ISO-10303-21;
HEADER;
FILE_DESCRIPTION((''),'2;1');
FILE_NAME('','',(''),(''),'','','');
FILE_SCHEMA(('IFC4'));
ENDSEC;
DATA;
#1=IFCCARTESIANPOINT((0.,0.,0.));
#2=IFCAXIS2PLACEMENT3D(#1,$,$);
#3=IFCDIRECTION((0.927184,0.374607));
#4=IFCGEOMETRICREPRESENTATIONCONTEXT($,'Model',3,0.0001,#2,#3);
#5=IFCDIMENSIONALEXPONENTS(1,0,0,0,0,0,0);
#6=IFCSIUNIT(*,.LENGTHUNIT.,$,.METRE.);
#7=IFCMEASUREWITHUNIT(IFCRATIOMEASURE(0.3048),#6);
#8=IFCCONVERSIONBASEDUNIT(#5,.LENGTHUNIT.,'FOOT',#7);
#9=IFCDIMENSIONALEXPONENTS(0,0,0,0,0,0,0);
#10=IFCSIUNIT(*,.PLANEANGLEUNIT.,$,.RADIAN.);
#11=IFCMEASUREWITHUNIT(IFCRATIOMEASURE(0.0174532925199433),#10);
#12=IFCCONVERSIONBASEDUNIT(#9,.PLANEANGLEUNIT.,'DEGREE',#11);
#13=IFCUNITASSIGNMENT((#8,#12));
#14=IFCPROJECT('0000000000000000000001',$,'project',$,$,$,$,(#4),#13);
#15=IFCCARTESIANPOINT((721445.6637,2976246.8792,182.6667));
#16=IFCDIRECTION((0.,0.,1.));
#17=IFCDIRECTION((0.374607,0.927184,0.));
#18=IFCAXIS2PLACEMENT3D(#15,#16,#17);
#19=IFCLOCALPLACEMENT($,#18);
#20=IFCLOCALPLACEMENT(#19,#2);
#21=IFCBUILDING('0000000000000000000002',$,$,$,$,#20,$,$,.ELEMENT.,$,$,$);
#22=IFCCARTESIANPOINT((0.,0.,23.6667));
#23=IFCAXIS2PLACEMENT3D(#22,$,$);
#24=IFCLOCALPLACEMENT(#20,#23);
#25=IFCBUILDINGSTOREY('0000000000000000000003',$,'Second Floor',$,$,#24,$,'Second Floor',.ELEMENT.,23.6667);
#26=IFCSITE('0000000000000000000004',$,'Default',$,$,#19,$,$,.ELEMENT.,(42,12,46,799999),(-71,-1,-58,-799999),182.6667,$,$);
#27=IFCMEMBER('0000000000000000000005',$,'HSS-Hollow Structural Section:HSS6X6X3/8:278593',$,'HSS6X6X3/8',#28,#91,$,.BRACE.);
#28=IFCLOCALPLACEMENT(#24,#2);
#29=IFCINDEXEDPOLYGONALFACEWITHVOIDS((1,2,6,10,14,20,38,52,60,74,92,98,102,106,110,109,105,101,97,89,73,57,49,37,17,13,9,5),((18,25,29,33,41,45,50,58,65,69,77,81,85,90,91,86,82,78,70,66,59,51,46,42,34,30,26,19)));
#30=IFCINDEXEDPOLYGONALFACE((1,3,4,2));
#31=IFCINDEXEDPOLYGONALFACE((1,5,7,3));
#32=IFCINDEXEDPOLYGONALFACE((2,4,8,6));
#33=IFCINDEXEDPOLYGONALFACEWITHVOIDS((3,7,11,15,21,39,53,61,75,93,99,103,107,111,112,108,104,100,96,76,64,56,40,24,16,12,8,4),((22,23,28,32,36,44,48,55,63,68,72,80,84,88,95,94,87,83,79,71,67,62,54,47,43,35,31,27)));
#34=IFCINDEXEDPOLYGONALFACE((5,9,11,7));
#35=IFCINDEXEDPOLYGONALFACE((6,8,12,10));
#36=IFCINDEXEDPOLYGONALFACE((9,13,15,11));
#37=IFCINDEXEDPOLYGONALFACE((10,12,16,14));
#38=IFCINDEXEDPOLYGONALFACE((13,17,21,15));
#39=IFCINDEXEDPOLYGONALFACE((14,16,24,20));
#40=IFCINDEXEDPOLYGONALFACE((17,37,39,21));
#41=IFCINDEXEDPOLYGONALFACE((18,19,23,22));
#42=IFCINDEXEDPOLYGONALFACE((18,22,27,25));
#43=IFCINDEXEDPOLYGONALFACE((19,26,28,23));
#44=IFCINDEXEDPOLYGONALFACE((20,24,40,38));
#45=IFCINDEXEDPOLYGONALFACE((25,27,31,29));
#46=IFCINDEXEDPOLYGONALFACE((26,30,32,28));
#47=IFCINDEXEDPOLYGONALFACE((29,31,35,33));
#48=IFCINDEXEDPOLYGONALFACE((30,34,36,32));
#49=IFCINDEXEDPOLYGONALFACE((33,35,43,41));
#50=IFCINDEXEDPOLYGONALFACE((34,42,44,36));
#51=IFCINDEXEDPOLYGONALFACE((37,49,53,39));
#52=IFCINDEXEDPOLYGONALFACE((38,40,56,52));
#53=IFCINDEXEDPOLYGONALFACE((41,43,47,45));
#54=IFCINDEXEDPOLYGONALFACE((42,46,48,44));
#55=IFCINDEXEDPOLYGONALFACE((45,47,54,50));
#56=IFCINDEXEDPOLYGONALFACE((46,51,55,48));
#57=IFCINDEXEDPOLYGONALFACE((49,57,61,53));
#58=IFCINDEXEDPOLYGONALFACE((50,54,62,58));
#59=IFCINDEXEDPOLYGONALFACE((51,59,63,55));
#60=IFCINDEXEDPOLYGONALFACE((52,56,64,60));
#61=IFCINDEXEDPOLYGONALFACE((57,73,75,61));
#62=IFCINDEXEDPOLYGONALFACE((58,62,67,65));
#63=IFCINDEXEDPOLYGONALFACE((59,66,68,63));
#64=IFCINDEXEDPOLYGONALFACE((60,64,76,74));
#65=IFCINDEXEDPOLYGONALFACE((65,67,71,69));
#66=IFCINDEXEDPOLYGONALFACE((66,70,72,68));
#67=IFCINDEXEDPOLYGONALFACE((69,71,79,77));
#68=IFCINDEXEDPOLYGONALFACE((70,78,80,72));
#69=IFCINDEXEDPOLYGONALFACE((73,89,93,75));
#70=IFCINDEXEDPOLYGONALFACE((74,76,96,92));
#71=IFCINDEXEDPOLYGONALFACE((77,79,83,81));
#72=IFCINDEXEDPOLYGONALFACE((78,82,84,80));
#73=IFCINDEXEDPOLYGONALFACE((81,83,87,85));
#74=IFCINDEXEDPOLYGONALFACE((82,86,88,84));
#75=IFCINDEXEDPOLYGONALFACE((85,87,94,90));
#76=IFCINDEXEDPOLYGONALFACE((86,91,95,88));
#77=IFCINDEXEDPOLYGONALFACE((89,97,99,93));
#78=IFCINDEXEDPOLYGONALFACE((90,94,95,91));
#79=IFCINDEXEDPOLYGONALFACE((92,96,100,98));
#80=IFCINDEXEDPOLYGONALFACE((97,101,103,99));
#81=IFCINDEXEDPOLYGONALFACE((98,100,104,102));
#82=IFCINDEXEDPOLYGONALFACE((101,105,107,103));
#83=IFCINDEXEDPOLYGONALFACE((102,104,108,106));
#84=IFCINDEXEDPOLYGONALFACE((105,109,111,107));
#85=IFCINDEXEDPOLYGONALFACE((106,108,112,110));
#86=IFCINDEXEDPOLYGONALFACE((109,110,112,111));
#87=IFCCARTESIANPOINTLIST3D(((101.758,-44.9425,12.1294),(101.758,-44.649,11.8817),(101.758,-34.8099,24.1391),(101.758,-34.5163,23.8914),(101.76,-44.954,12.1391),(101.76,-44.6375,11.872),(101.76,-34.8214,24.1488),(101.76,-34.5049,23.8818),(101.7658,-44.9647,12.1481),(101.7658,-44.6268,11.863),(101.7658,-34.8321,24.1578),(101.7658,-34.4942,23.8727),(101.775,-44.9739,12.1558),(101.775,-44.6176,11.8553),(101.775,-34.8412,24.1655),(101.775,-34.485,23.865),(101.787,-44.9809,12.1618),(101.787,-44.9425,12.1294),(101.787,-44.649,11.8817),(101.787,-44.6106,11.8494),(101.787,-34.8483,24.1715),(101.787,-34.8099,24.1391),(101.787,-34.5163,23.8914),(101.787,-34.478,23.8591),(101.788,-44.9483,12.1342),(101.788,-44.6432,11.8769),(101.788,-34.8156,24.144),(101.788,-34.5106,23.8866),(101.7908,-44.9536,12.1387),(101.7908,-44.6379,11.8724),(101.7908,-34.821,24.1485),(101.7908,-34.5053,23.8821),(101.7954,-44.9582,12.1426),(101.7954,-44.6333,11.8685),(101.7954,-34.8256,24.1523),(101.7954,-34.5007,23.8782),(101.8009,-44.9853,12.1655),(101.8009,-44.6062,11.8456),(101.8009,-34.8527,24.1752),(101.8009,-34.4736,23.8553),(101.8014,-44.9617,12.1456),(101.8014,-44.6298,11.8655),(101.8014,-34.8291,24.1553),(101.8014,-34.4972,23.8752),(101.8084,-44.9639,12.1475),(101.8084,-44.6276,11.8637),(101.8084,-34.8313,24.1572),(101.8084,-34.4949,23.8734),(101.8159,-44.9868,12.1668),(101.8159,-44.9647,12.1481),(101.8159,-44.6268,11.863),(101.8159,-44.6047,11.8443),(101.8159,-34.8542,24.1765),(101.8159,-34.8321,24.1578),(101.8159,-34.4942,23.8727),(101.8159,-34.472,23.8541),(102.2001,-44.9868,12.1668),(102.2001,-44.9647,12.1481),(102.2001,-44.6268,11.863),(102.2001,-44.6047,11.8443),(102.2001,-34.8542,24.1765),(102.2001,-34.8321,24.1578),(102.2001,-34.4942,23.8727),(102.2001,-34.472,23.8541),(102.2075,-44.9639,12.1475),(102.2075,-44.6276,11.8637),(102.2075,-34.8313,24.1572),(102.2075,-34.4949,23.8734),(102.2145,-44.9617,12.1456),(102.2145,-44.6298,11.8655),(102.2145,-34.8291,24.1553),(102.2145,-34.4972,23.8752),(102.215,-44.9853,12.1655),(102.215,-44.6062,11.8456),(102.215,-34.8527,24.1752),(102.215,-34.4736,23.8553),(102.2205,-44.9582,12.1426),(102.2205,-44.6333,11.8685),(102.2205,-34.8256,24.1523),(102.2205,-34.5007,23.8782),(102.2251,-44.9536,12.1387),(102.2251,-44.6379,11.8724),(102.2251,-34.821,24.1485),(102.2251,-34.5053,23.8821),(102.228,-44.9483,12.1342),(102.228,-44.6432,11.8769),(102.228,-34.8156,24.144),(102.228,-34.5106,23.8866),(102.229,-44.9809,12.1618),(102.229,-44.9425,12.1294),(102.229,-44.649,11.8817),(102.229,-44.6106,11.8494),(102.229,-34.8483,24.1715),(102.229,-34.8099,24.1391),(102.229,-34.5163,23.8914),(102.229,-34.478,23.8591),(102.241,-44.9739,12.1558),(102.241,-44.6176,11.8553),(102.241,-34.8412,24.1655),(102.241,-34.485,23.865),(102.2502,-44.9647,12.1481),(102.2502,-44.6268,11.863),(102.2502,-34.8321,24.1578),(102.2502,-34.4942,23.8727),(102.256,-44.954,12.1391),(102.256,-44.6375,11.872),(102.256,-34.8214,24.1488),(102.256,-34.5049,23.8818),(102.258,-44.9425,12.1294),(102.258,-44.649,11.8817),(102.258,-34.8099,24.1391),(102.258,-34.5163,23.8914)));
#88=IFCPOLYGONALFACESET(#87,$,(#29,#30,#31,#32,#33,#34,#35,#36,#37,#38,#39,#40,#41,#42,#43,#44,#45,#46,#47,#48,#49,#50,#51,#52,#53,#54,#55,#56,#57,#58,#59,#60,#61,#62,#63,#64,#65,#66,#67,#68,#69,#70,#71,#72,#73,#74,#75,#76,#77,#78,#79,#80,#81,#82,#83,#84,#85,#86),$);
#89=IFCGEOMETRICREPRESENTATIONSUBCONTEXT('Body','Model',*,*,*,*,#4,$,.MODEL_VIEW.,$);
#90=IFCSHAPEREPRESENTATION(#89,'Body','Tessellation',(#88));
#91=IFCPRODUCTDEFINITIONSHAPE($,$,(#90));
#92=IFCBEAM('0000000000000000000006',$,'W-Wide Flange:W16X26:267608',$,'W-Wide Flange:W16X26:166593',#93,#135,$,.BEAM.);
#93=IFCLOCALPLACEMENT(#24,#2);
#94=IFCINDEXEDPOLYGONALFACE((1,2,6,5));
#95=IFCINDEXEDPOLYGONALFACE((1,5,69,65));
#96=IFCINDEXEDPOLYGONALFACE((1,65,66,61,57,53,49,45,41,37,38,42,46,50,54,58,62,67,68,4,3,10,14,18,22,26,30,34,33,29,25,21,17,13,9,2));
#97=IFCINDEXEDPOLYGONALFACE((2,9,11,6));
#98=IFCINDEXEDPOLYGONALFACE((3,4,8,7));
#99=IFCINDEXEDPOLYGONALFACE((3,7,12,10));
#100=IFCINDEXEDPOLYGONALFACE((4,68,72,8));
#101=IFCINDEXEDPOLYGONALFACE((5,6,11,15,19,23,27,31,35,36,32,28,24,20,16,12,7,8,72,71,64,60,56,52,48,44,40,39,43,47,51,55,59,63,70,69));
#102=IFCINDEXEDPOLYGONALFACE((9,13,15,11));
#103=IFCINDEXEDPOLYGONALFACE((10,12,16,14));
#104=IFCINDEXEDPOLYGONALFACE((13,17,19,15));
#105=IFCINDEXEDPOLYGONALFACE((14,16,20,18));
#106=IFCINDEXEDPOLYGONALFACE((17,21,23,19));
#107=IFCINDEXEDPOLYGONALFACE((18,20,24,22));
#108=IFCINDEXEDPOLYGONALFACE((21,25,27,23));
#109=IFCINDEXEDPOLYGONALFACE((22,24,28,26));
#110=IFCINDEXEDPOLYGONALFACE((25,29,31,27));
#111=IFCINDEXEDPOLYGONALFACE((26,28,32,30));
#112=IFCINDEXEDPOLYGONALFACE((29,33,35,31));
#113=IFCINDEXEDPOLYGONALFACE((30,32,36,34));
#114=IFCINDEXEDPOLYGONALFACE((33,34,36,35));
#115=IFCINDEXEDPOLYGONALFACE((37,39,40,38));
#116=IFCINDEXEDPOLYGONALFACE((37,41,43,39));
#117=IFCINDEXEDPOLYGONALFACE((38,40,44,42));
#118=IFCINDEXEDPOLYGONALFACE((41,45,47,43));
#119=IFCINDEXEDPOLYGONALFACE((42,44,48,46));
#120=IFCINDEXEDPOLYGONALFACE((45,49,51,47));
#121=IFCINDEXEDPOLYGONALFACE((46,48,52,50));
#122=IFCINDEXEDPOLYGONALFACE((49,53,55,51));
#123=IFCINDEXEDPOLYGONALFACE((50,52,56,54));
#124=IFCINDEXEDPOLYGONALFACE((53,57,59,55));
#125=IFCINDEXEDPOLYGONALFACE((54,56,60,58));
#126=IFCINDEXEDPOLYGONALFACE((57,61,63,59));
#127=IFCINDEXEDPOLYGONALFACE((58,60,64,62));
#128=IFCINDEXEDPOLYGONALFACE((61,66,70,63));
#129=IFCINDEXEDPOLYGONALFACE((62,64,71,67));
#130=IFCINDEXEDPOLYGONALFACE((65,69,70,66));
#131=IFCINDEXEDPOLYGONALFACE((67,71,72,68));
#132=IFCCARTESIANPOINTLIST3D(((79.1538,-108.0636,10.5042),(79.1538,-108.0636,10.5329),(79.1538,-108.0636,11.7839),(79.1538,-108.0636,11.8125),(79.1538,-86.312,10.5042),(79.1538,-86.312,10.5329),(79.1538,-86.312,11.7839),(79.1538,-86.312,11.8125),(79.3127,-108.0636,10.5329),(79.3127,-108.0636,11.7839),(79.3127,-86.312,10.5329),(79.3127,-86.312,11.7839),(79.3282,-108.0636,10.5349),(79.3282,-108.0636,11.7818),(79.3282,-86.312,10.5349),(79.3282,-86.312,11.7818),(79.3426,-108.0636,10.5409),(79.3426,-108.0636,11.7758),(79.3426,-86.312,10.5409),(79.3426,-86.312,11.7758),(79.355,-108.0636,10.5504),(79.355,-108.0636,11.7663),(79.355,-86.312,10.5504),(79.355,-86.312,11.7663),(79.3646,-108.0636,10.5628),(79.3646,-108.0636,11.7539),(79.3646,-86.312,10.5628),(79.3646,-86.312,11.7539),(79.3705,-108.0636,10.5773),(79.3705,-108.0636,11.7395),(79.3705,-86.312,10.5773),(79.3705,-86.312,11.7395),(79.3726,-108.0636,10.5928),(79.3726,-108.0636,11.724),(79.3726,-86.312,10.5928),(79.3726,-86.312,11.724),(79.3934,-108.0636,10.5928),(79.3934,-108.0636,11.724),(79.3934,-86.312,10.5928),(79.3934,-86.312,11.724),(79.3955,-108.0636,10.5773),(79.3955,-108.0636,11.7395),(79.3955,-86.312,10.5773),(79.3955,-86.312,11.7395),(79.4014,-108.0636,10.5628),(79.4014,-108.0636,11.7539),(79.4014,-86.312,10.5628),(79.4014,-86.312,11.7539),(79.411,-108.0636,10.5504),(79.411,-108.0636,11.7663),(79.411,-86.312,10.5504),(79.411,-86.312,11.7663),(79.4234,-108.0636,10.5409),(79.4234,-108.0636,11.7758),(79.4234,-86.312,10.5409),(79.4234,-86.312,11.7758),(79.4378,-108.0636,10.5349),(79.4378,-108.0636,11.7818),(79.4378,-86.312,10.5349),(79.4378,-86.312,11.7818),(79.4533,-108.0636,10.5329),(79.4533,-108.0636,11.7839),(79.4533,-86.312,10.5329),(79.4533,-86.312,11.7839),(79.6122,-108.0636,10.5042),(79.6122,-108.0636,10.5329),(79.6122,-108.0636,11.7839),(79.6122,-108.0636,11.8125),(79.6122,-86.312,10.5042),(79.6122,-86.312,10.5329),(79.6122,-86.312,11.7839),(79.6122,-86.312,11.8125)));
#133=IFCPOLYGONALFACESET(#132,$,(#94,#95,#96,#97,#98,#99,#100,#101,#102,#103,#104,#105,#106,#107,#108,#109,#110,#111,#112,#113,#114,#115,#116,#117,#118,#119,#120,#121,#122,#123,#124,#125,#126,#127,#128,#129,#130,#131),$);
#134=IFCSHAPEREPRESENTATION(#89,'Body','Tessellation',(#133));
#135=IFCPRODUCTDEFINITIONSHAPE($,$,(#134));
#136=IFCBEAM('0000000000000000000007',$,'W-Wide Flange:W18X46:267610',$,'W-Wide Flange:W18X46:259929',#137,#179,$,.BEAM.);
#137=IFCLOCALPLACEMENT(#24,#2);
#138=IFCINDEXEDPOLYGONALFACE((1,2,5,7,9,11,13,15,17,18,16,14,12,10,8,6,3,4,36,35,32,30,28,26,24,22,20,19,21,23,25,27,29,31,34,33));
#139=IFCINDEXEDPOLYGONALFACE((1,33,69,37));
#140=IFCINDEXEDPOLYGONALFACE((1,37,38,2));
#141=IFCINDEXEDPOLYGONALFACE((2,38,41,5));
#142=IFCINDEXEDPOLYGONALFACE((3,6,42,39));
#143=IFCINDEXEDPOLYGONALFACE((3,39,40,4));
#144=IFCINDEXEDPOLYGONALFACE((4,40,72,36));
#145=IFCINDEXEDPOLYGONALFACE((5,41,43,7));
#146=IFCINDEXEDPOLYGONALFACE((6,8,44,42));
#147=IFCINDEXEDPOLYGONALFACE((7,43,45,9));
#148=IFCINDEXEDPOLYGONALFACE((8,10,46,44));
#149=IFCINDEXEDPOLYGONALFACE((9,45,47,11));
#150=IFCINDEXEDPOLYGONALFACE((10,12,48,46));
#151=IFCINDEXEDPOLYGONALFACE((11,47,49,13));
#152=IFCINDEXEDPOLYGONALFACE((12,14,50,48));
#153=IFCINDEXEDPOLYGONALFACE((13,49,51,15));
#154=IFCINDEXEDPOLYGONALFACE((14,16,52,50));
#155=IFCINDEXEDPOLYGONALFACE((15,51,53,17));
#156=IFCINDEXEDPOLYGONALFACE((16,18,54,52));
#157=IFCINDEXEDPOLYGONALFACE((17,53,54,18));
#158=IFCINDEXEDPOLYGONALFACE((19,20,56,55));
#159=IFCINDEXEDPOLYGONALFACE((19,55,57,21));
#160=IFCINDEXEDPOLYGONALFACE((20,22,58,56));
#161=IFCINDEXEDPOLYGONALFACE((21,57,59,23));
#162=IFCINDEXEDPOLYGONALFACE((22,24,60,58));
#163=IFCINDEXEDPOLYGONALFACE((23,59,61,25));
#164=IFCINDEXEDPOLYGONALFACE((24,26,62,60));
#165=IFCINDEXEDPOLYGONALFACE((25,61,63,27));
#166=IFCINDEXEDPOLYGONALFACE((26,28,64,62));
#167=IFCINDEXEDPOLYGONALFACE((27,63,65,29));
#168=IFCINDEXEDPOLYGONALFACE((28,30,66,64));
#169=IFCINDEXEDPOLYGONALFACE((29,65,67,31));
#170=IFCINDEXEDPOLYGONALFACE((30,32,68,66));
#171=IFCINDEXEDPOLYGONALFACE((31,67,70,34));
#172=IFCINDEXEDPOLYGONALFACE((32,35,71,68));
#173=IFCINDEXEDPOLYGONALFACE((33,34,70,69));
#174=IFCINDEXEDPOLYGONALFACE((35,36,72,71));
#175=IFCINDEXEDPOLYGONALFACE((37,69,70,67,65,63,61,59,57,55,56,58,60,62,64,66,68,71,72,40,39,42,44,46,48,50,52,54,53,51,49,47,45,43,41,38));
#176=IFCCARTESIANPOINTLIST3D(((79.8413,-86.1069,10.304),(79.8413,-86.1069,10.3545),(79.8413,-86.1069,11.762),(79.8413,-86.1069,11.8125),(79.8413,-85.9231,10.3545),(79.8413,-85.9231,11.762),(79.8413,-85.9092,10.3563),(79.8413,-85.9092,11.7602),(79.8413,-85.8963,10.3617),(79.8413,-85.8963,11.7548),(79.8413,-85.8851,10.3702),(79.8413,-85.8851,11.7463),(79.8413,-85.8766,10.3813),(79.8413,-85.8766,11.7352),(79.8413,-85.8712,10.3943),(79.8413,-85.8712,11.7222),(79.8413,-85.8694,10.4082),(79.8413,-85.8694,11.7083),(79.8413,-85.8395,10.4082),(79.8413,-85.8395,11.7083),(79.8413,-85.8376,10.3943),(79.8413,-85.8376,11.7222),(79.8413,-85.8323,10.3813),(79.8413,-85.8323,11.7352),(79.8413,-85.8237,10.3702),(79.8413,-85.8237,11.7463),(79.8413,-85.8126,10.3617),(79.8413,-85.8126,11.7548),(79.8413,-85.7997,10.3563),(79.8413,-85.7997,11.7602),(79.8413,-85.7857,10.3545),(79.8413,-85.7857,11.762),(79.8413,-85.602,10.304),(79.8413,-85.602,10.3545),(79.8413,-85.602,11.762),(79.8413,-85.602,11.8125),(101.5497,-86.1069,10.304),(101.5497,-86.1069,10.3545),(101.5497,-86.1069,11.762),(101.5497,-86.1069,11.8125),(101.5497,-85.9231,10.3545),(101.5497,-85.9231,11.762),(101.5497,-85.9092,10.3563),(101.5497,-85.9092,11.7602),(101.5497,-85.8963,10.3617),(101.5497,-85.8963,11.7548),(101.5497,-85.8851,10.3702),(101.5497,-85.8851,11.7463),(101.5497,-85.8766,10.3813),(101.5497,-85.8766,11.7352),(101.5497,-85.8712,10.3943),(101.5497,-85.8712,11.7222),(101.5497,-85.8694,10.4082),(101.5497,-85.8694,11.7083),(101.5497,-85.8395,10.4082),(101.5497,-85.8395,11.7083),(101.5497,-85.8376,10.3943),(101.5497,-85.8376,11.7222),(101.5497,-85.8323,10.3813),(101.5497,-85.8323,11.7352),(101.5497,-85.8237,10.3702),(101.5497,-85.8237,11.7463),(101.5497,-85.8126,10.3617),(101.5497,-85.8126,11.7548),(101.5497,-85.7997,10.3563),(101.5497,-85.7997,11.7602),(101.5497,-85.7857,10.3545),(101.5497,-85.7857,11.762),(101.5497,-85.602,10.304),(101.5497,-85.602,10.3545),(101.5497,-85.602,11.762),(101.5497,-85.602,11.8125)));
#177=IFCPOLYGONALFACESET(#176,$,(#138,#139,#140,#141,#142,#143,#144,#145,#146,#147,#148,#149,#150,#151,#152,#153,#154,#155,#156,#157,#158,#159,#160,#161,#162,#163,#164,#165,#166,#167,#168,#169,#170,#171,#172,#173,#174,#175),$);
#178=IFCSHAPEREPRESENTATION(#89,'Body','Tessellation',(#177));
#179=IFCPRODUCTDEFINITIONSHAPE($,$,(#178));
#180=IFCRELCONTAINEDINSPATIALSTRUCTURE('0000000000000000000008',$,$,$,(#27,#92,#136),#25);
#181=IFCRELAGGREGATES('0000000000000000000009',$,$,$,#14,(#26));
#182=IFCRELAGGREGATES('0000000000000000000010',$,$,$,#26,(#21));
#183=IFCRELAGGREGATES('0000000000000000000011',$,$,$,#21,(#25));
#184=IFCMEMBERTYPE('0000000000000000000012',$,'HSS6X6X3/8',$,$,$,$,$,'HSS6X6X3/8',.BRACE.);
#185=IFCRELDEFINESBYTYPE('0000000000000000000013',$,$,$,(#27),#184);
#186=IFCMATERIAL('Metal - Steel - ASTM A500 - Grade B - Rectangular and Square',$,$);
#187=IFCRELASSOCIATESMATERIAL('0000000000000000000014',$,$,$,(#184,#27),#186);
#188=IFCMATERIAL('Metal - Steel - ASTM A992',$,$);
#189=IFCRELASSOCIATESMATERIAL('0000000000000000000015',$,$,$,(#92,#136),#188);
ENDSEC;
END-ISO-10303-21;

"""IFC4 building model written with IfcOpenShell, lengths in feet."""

from ifc_helpers import new_model, entity, si_unit, converted_unit, direction, frame, frame_2d, origin, place, context, subcontext, project, spatial, polyline, circle_curve, parameter, trimmed, segment, composite_curve, i_section, outline, extrude, source, transform, mapped, material, type_object, type_shapes, element, save


model = new_model("IFC4")

# Units and contexts
model_context = context("Model", 3, precision=0.0001, world=origin(), true_north=direction((0.927184, 0.374607)))
body_context = subcontext(model_context, "Body", "Model", "MODEL_VIEW")
ifc_project = project(units=[converted_unit("LENGTHUNIT", "FOOT", entity("IfcRatioMeasure", 0.3048), si_unit("LENGTHUNIT", "METRE"), dimensions=[1, 0, 0, 0, 0, 0, 0]), converted_unit("PLANEANGLEUNIT", "DEGREE", entity("IfcRatioMeasure", 0.0174532925199433), si_unit("PLANEANGLEUNIT", "RADIAN"), dimensions=[0, 0, 0, 0, 0, 0, 0])], contexts=[model_context])

# Site, building, storey
site_placement = place(None, frame((721445.6637, 2976246.8792, 182.6667), z_axis=(0.0, 0.0, 1.0), x_axis=(0.374607, 0.927184, 0.0)))
site = spatial("IfcSite", under=ifc_project, at=site_placement, Name="Default", CompositionType="ELEMENT", RefLatitude=(42, 12, 46, 799999), RefLongitude=(-71, -1, -58, -799999), RefElevation=182.6667)
building_placement = place(site_placement, origin())
building = spatial("IfcBuilding", under=site, at=building_placement, CompositionType="ELEMENT")
storey_placement = place(building_placement, frame((0.0, 0.0, 23.6667)))
storey = spatial("IfcBuildingStorey", under=building, at=storey_placement, Name="Second Floor", LongName="Second Floor", CompositionType="ELEMENT", Elevation=23.6667)

# Shared definitions
ifc_material_1 = material(Name="Metal - Steel - ASTM A992")

# Member
ifc_material_2 = material(Name="Metal - Steel - ASTM A500 - Grade B - Rectangular and Square")
member_type = type_object("IfcMemberType", Name="HSS6X6X3/8", ElementType="HSS6X6X3/8", PredefinedType="BRACE", material=ifc_material_2)
shared_shape_1 = source(origin(), body_context, "Body", "SweptSolid", [
    extrude(outline(composite_curve([segment(trimmed(circle_curve(frame_2d((-0.1921, -0.1921), x_axis=(1.0, 0.0)), 0.0579), [parameter(180.0)], [parameter(270.0)], True, "PARAMETER"), True, "CONTINUOUS"), segment(polyline([(-0.1921, -0.25), (0.1921, -0.25)]), True, "CONTINUOUS"), segment(trimmed(circle_curve(frame_2d((0.1921, -0.1921), x_axis=(1.0, 0.0)), 0.0579), [parameter(270.0)], [parameter(0.0)], True, "PARAMETER"), True, "CONTINUOUS"), segment(polyline([(0.25, -0.1921), (0.25, 0.1921)]), True, "CONTINUOUS"), segment(trimmed(circle_curve(frame_2d((0.1921, 0.1921), x_axis=(1.0, 0.0)), 0.0579), [parameter(360.0)], [parameter(90.0)], True, "PARAMETER"), True, "CONTINUOUS"), segment(polyline([(0.1921, 0.25), (-0.1921, 0.25)]), True, "CONTINUOUS"), segment(trimmed(circle_curve(frame_2d((-0.1921, 0.1921), x_axis=(1.0, 0.0)), 0.0579), [parameter(90.0)], [parameter(180.0)], True, "PARAMETER"), True, "CONTINUOUS"), segment(polyline([(-0.25, 0.1921), (-0.25, -0.1921)]), True, "CONTINUOUS")], self_intersect=False), holes=[composite_curve([segment(polyline([(0.1921, -0.221), (-0.1921, -0.221)]), True, "CONTINUOUS"), segment(trimmed(circle_curve(frame_2d((-0.1921, -0.1921), x_axis=(1.0, 0.0)), 0.029), [parameter(180.0)], [parameter(270.0)], True, "PARAMETER"), False, "CONTINUOUS"), segment(polyline([(-0.221, -0.1921), (-0.221, 0.1921)]), True, "CONTINUOUS"), segment(trimmed(circle_curve(frame_2d((-0.1921, 0.1921), x_axis=(1.0, 0.0)), 0.029), [parameter(90.0)], [parameter(180.0)], True, "PARAMETER"), False, "CONTINUOUS"), segment(polyline([(-0.1921, 0.221), (0.1921, 0.221)]), True, "CONTINUOUS"), segment(trimmed(circle_curve(frame_2d((0.1921, 0.1921), x_axis=(1.0, 0.0)), 0.029), [parameter(0.0)], [parameter(90.0)], True, "PARAMETER"), False, "CONTINUOUS"), segment(polyline([(0.221, 0.1921), (0.221, -0.1921)]), True, "CONTINUOUS"), segment(trimmed(circle_curve(frame_2d((0.1921, -0.1921), x_axis=(1.0, 0.0)), 0.029), [parameter(270.0)], [parameter(0.0)], True, "PARAMETER"), False, "CONTINUOUS")], self_intersect=False)]), frame((-7.8566, 0.0, 0.0), z_axis=(1.0, 0.0, 0.0), x_axis=(0.0, -1.0, 0.0)), (0.0, 0.0, 1.0), 15.7132),
])
type_shapes(member_type, [shared_shape_1])
member_placement = place(storey_placement, frame((102.008, -39.7294, 18.0104), z_axis=(0.0, -0.764309, 0.64485), x_axis=(0.0, 0.64485, 0.764309)))
element("IfcMember", 1, at=member_placement, inside=storey, type_object=member_type, material=ifc_material_2, Name="HSS-Hollow Structural Section:HSS6X6X3/8:278593", ObjectType="HSS6X6X3/8", PredefinedType="BRACE", context=body_context, shape_type="MappedRepresentation", body=[
    mapped(shared_shape_1, transform((0.0, 0.0, 0.0), scale=1.0)),
])

# Beams
beam_1_placement = place(storey_placement, frame((79.383, -85.8544, 11.8125), z_axis=(0.0, 0.0, 1.0), x_axis=(0.0, -1.0, 0.0)))
element("IfcBeam", 2, at=beam_1_placement, inside=storey, material=ifc_material_1, Name="W-Wide Flange:W16X26:267608", ObjectType="W-Wide Flange:W16X26:166593", PredefinedType="BEAM", context=body_context, shape_type="SweptSolid", body=[
    extrude(i_section(OverallWidth=0.4583, OverallDepth=1.3083, WebThickness=0.0208, FlangeThickness=0.0286, FilletRadius=0.0599, at=frame_2d((0.0, 0.0), x_axis=(0.0, 1.0))), frame((0.4575, 0.0, -0.6541), z_axis=(1.0, 0.0, 0.0), x_axis=(0.0, 0.0, -1.0)), (0.0, 0.0, 1.0), 21.7516),
])
beam_2_placement = place(storey_placement, frame((79.383, -85.8544, 11.8125)))
element("IfcBeam", 3, at=beam_2_placement, inside=storey, material=ifc_material_1, Name="W-Wide Flange:W18X46:267610", ObjectType="W-Wide Flange:W18X46:259929", PredefinedType="BEAM", context=body_context, shape_type="SweptSolid", body=[
    extrude(i_section(OverallWidth=0.5049, OverallDepth=1.5085, WebThickness=0.0299, FlangeThickness=0.0505, FilletRadius=0.0537, at=frame_2d((0.0, 0.0), x_axis=(0.0, 1.0))), frame((0.4583, 0.0, -0.7542), z_axis=(1.0, 0.0, 0.0), x_axis=(0.0, 0.0, -1.0)), (0.0, 0.0, 1.0), 21.7083),
])

save(model, "model.ifc")
